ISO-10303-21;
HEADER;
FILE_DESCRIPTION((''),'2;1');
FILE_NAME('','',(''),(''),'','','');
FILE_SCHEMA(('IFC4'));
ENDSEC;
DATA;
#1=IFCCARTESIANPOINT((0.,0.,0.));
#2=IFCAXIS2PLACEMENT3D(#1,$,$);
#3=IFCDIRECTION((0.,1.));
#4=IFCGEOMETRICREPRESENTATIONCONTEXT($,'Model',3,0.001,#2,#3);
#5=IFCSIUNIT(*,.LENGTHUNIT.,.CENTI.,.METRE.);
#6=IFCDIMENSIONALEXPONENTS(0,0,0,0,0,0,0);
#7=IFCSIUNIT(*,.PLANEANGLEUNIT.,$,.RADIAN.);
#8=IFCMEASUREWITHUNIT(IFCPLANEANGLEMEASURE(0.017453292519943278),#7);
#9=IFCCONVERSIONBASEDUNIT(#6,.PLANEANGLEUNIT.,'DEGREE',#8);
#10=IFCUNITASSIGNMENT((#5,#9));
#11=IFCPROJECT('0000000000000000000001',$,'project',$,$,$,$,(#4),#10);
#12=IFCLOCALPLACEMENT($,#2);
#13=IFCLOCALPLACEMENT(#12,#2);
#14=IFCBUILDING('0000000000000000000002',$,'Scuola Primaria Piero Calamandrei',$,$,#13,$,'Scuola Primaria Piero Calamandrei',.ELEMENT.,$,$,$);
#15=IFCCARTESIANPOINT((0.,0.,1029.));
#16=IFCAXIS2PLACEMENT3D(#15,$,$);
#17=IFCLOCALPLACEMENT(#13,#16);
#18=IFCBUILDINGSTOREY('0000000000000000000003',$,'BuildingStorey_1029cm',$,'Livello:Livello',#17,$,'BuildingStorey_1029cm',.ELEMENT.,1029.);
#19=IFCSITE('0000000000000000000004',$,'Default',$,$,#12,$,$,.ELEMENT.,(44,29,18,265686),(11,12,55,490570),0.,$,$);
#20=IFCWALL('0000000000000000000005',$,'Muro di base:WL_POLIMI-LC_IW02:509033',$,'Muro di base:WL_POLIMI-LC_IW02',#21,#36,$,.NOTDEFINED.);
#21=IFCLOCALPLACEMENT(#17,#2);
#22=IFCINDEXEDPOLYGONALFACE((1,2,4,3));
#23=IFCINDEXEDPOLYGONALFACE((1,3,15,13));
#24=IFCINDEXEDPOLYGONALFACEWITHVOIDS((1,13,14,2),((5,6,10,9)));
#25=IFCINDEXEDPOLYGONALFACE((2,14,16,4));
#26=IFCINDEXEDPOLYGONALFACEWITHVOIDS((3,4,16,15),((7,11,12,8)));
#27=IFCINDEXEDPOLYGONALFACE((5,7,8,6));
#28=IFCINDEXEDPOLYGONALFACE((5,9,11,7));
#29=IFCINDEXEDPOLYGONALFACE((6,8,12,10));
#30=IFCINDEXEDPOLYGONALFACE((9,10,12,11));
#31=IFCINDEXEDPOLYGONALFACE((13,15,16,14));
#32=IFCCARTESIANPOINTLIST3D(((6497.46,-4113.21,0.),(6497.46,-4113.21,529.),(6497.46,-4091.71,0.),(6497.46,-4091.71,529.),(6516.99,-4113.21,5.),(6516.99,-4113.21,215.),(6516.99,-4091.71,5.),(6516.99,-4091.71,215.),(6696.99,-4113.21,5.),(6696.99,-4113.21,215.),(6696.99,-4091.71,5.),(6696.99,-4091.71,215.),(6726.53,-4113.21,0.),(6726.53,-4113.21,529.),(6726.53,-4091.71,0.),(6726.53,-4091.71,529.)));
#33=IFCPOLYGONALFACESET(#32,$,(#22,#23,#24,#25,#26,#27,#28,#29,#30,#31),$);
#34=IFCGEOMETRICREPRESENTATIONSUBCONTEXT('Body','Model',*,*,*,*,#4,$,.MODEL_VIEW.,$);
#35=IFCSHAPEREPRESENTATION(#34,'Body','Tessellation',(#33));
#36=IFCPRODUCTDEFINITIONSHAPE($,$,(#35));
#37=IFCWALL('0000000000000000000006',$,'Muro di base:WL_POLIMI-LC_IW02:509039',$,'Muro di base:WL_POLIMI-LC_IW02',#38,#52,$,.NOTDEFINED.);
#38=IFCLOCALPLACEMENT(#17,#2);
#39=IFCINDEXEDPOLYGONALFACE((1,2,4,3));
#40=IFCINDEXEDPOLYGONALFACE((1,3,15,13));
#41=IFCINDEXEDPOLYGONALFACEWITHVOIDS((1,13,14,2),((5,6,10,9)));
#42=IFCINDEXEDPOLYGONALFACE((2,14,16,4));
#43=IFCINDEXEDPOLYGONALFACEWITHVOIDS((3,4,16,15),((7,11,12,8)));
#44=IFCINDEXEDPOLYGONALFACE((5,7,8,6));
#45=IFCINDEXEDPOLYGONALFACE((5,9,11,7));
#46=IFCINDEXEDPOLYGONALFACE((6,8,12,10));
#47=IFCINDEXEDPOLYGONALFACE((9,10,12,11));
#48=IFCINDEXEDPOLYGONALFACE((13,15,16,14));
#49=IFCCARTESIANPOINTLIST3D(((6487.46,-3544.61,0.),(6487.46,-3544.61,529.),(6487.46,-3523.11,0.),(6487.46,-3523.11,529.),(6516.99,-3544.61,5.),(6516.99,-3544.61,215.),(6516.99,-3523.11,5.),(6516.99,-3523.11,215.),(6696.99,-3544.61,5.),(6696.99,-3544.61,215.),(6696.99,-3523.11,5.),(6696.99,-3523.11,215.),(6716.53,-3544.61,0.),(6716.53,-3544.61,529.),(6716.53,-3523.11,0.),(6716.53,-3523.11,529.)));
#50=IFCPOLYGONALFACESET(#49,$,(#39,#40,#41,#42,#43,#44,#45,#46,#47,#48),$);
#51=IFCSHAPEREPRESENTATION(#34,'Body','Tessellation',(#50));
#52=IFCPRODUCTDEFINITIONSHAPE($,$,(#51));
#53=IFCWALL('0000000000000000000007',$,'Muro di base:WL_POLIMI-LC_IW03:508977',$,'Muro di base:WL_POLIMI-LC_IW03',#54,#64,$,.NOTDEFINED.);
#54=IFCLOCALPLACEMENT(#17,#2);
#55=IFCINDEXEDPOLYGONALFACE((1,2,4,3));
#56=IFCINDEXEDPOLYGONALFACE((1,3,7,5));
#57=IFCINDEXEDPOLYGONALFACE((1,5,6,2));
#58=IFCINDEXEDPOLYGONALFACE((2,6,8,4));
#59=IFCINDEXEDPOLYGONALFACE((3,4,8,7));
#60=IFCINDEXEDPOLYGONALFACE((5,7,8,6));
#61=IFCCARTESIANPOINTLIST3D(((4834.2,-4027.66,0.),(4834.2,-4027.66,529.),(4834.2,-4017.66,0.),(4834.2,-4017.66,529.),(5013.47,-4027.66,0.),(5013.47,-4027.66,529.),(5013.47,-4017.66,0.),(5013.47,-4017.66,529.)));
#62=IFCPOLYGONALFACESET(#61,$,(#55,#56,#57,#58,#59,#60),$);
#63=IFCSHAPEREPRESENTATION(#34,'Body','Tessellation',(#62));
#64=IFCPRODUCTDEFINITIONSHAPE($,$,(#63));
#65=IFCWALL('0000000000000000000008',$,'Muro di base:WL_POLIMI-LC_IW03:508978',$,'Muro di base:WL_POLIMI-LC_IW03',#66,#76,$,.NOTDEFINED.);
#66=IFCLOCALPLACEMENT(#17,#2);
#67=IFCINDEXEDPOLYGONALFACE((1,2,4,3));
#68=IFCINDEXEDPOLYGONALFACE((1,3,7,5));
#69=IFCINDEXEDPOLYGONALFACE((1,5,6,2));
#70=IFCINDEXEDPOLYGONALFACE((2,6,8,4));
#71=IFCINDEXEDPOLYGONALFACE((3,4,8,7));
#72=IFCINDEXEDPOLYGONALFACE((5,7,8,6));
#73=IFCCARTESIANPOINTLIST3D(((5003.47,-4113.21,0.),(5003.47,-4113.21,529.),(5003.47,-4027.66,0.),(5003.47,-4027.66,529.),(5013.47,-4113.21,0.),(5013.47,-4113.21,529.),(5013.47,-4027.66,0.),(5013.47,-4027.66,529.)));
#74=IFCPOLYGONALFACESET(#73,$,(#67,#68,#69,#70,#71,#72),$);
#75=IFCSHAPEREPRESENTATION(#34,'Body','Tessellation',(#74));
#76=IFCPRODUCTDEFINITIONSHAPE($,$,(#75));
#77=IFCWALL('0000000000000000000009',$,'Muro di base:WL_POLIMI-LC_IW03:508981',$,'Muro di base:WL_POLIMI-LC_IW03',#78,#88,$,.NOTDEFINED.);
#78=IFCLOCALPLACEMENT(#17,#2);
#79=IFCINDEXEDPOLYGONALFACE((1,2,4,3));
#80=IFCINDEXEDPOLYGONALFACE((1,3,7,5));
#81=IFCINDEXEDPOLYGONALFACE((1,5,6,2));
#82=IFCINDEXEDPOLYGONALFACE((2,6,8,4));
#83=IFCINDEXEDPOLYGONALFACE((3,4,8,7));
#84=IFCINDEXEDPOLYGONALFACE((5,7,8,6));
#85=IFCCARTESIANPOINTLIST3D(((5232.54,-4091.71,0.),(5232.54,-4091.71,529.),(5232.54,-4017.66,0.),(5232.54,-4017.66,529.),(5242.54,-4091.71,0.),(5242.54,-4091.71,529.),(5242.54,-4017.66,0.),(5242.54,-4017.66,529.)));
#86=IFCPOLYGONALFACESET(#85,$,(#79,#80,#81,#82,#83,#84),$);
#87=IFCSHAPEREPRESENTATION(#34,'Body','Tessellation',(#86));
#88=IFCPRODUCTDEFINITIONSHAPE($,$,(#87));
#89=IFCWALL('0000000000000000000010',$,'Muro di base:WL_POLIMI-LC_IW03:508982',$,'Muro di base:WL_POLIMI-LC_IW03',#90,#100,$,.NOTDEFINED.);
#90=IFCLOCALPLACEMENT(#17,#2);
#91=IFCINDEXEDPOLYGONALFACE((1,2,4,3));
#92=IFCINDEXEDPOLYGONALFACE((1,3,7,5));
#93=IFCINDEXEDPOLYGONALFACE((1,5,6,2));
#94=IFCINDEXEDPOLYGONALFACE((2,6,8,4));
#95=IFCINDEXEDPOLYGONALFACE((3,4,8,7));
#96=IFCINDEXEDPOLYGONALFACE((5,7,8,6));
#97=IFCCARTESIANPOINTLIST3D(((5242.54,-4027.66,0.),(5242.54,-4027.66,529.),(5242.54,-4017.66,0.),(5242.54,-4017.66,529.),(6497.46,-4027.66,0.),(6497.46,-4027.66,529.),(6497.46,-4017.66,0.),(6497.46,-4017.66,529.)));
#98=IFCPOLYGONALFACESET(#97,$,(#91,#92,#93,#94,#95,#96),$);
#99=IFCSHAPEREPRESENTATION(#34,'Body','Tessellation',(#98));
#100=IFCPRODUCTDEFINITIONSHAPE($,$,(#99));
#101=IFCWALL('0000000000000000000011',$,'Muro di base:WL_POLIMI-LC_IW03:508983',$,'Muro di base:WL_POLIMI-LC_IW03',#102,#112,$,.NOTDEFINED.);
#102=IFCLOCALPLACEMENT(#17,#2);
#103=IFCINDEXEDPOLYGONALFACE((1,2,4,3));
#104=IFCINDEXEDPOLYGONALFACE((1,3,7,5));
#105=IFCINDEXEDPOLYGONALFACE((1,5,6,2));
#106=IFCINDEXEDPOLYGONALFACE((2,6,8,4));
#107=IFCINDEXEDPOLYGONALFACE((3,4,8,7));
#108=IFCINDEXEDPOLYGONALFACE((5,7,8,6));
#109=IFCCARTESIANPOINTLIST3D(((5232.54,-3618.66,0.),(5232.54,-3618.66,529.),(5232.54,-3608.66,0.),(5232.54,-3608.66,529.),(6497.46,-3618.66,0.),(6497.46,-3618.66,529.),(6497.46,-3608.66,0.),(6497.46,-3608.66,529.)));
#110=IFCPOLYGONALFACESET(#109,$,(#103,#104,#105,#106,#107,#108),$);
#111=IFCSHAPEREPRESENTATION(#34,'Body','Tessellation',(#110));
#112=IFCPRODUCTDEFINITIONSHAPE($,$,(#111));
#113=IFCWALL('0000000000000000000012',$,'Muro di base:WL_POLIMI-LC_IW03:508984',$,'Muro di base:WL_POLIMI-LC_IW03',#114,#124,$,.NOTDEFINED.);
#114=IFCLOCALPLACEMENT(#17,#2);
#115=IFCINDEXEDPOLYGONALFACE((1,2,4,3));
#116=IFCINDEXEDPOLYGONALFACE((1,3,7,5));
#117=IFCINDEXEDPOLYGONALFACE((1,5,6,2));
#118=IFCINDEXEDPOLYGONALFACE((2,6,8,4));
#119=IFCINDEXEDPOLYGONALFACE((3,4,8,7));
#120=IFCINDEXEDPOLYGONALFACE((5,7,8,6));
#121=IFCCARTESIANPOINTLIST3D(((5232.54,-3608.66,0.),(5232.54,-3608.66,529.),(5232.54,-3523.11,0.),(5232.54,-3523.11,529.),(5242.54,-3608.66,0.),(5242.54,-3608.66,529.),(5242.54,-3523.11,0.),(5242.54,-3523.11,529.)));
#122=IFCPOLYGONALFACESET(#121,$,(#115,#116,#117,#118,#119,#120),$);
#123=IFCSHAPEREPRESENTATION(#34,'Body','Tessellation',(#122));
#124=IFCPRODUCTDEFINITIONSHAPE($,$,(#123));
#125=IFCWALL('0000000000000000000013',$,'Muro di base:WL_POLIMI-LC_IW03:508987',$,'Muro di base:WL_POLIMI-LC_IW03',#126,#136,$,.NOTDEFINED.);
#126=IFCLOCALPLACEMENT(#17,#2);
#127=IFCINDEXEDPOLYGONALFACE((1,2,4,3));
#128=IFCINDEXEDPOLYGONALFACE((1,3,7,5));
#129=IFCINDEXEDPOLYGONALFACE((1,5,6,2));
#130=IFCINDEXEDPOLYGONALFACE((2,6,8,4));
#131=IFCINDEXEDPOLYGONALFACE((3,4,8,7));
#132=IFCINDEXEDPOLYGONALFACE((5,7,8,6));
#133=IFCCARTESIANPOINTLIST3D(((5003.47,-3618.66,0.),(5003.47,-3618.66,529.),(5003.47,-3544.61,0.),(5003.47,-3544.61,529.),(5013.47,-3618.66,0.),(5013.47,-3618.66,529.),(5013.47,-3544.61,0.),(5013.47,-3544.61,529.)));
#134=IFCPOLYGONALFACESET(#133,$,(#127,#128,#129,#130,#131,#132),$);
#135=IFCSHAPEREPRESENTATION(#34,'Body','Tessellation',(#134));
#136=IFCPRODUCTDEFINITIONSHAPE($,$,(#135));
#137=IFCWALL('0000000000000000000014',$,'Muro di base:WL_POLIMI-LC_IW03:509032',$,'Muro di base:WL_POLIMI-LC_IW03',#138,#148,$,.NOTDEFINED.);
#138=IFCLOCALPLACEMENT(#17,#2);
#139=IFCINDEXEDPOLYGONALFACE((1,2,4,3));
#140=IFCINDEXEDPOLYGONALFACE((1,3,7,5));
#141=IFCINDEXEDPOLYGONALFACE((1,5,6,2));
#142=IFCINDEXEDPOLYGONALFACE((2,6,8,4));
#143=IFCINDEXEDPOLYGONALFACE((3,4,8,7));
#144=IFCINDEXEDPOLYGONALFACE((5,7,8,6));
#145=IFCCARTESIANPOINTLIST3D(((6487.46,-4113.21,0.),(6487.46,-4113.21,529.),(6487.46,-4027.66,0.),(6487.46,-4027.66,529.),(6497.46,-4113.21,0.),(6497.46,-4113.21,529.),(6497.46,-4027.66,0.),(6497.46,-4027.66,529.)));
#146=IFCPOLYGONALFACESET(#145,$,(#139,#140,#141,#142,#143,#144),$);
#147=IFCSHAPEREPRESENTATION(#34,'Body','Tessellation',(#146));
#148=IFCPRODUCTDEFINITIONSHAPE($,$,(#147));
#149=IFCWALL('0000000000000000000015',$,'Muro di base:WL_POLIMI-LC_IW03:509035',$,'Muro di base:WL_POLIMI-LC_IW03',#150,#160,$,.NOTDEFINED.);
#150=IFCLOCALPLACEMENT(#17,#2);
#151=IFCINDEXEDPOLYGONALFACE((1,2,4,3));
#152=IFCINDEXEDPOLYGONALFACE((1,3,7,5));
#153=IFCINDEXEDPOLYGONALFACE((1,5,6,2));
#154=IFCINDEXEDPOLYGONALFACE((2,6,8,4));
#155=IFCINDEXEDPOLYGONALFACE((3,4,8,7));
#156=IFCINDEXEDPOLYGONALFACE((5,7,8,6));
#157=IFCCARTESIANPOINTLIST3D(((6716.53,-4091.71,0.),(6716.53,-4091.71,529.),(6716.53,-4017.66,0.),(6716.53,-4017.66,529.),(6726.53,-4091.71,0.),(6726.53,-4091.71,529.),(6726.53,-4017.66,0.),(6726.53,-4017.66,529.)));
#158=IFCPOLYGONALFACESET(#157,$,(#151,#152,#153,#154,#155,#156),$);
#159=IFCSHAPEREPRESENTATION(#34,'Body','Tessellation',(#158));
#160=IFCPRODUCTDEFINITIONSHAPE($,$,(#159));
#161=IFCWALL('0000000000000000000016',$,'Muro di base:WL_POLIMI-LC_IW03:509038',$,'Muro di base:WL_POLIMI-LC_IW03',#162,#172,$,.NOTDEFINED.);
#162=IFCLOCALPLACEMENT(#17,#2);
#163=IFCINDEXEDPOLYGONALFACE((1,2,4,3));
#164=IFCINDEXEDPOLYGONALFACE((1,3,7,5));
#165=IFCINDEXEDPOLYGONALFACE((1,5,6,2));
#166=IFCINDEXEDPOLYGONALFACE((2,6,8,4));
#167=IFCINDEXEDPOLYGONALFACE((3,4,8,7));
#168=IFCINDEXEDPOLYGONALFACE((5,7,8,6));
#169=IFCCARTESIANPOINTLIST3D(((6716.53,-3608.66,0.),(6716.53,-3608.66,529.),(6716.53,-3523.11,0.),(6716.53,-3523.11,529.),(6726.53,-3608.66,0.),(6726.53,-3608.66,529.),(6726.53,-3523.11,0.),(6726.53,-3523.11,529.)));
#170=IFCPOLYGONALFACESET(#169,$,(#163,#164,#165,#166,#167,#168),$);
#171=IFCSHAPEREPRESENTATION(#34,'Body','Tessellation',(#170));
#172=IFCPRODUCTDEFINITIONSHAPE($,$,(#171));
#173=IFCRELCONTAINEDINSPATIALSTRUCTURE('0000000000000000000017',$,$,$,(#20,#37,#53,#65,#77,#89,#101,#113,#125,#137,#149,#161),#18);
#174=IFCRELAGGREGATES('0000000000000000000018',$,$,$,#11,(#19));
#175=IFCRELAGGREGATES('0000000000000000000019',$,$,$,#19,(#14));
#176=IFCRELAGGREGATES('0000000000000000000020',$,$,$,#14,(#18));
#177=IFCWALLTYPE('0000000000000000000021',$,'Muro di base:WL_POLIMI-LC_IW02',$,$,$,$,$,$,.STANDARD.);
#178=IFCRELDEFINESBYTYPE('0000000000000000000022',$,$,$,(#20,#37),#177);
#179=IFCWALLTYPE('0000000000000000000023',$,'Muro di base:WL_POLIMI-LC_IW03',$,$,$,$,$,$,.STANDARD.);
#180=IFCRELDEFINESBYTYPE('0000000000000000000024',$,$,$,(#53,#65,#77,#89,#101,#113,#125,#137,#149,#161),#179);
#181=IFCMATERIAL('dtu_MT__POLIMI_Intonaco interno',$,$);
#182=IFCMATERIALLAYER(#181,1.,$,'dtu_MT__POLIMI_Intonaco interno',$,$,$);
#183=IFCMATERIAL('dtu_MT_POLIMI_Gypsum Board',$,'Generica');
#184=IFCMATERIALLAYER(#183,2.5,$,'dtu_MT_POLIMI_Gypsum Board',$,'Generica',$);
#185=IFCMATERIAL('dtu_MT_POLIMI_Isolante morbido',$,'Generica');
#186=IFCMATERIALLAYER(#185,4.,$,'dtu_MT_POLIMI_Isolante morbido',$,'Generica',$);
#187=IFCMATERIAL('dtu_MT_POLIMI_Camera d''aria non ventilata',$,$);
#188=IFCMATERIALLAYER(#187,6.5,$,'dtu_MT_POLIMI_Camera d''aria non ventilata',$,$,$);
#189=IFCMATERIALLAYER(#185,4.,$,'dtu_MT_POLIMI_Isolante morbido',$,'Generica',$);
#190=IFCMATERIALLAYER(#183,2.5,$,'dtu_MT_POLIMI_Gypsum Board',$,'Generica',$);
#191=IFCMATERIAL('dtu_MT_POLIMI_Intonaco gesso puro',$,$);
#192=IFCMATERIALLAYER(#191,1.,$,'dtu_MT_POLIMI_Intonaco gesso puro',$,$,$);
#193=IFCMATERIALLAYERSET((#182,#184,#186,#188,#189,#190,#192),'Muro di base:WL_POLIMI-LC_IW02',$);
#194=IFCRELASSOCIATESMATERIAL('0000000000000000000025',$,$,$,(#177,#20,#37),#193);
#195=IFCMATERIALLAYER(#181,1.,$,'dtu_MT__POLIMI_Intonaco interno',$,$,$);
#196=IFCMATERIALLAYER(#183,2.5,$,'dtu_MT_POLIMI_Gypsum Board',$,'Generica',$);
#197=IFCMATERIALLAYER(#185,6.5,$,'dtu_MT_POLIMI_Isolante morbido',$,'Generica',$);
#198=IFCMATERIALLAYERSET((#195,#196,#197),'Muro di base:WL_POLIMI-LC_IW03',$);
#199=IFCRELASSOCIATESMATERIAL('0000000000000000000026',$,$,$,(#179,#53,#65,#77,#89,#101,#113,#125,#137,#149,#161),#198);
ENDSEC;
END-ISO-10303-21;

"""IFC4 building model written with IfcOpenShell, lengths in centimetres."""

from ifc_helpers import new_model, entity, si_unit, converted_unit, direction, frame, frame_2d, origin, place, context, subcontext, project, spatial, rectangle, extrude, material, layer, layer_set, layer_usage, type_object, element, save


model = new_model("IFC4")

# Units and contexts
model_context = context("Model", 3, precision=0.001, world=origin(), true_north=direction((0.0, 1.0)))
body_context = subcontext(model_context, "Body", "Model", "MODEL_VIEW")
ifc_project = project(units=[si_unit("LENGTHUNIT", "METRE", prefix="CENTI"), converted_unit("PLANEANGLEUNIT", "DEGREE", entity("IfcPlaneAngleMeasure", 0.017453292519943278), si_unit("PLANEANGLEUNIT", "RADIAN"), dimensions=[0, 0, 0, 0, 0, 0, 0])], contexts=[model_context])

# Site, building, storey
site_placement = place(None, origin())
site = spatial("IfcSite", under=ifc_project, at=site_placement, Name="Default", CompositionType="ELEMENT", RefLatitude=(44, 29, 18, 265686), RefLongitude=(11, 12, 55, 490570), RefElevation=0.0)
building_placement = place(site_placement, origin())
building = spatial("IfcBuilding", under=site, at=building_placement, Name="Scuola Primaria Piero Calamandrei", LongName="Scuola Primaria Piero Calamandrei", CompositionType="ELEMENT")
storey_placement = place(building_placement, frame((0.0, 0.0, 1029.0)))
storey = spatial("IfcBuildingStorey", under=building, at=storey_placement, Name="BuildingStorey_1029cm", ObjectType="Livello:Livello", LongName="BuildingStorey_1029cm", CompositionType="ELEMENT", Elevation=1029.0)

# Shared definitions
ifc_material_1 = material(Name="dtu_MT_POLIMI_Isolante morbido", Category="Generica")
ifc_material_2 = material(Name="dtu_MT_POLIMI_Gypsum Board", Category="Generica")
ifc_material_3 = material(Name="dtu_MT__POLIMI_Intonaco interno")

# Walls, openings
ifc_layer_1 = layer(ifc_material_3, 1.0, Name="dtu_MT__POLIMI_Intonaco interno")
ifc_layer_2 = layer(ifc_material_2, 2.5, Name="dtu_MT_POLIMI_Gypsum Board", Category="Generica")
ifc_layer_3 = layer(ifc_material_1, 4.0, Name="dtu_MT_POLIMI_Isolante morbido", Category="Generica")
ifc_material_4 = material(Name="dtu_MT_POLIMI_Camera d'aria non ventilata")
ifc_layer_4 = layer(ifc_material_4, 6.5, Name="dtu_MT_POLIMI_Camera d'aria non ventilata")
ifc_layer_5 = layer(ifc_material_1, 4.0, Name="dtu_MT_POLIMI_Isolante morbido", Category="Generica")
ifc_layer_6 = layer(ifc_material_2, 2.5, Name="dtu_MT_POLIMI_Gypsum Board", Category="Generica")
ifc_material_5 = material(Name="dtu_MT_POLIMI_Intonaco gesso puro")
ifc_layer_7 = layer(ifc_material_5, 1.0, Name="dtu_MT_POLIMI_Intonaco gesso puro")
ifc_layer_set_1 = layer_set([ifc_layer_1, ifc_layer_2, ifc_layer_3, ifc_layer_4, ifc_layer_5, ifc_layer_6, ifc_layer_7], Name="Muro di base:WL_POLIMI-LC_IW02")
wall_type_1 = type_object("IfcWallType", Name="Muro di base:WL_POLIMI-LC_IW02", PredefinedType="STANDARD", material=ifc_layer_set_1)
ifc_layer_usage_1 = layer_usage(ifc_layer_set_1, "AXIS2", "NEGATIVE", 10.75)
wall_1_placement = place(storey_placement, frame((6726.53, -4102.46, 0.0), z_axis=(0.0, 0.0, 1.0), x_axis=(-1.0, 0.0, 0.0)))
wall_1 = element("IfcWall", 1, at=wall_1_placement, inside=storey, type_object=wall_type_1, material=ifc_layer_usage_1, Name="Muro di base:WL_POLIMI-LC_IW02:509033", ObjectType="Muro di base:WL_POLIMI-LC_IW02", PredefinedType="NOTDEFINED", context=body_context, shape_type="SweptSolid", body=[
    extrude(rectangle(XDim=229.07, YDim=21.5, at=frame_2d((114.54, 0.0), x_axis=(-1.0, 0.0))), origin(), (0.0, 0.0, 1.0), 529.0),
])
opening_1_placement = place(wall_1_placement, frame((209.54, 10.75, 5.0)))
element("IfcOpeningElement", 2, at=opening_1_placement, cuts=wall_1, PredefinedType="OPENING", context=body_context, shape_type="SweptSolid", body=[
    extrude(rectangle(XDim=210.0, YDim=180.0, at=frame_2d((105.0, 90.0), x_axis=(-1.0, 0.0))), frame((0.0, 0.0, 0.0), z_axis=(0.0, -1.0, 0.0), x_axis=(0.0, 0.0, 1.0)), (0.0, 0.0, 1.0), 21.5),
])
ifc_layer_usage_2 = layer_usage(ifc_layer_set_1, "AXIS2", "NEGATIVE", 10.75)
wall_2_placement = place(storey_placement, frame((6487.46, -3533.86, 0.0)))
wall_2 = element("IfcWall", 3, at=wall_2_placement, inside=storey, type_object=wall_type_1, material=ifc_layer_usage_2, Name="Muro di base:WL_POLIMI-LC_IW02:509039", ObjectType="Muro di base:WL_POLIMI-LC_IW02", PredefinedType="NOTDEFINED", context=body_context, shape_type="SweptSolid", body=[
    extrude(rectangle(XDim=229.07, YDim=21.5, at=frame_2d((114.54, 0.0), x_axis=(-1.0, 0.0))), origin(), (0.0, 0.0, 1.0), 529.0),
])
opening_2_placement = place(wall_2_placement, frame((209.54, 10.75, 5.0)))
element("IfcOpeningElement", 4, at=opening_2_placement, cuts=wall_2, PredefinedType="OPENING", context=body_context, shape_type="SweptSolid", body=[
    extrude(rectangle(XDim=210.0, YDim=180.0, at=frame_2d((105.0, 90.0), x_axis=(-1.0, 0.0))), frame((0.0, 0.0, 0.0), z_axis=(0.0, -1.0, 0.0), x_axis=(0.0, 0.0, 1.0)), (0.0, 0.0, 1.0), 21.5),
])

# Walls
ifc_layer_8 = layer(ifc_material_3, 1.0, Name="dtu_MT__POLIMI_Intonaco interno")
ifc_layer_9 = layer(ifc_material_2, 2.5, Name="dtu_MT_POLIMI_Gypsum Board", Category="Generica")
ifc_layer_10 = layer(ifc_material_1, 6.5, Name="dtu_MT_POLIMI_Isolante morbido", Category="Generica")
ifc_layer_set_2 = layer_set([ifc_layer_8, ifc_layer_9, ifc_layer_10], Name="Muro di base:WL_POLIMI-LC_IW03")
ifc_layer_usage_3 = layer_usage(ifc_layer_set_2, "AXIS2", "NEGATIVE", 5.0)
wall_type_2 = type_object("IfcWallType", Name="Muro di base:WL_POLIMI-LC_IW03", PredefinedType="STANDARD", material=ifc_layer_set_2)
wall_3_placement = place(storey_placement, frame((5013.47, -4022.66, 0.0), z_axis=(0.0, 0.0, 1.0), x_axis=(-1.0, 0.0, 0.0)))
element("IfcWall", 5, at=wall_3_placement, inside=storey, type_object=wall_type_2, material=ifc_layer_usage_3, Name="Muro di base:WL_POLIMI-LC_IW03:508977", ObjectType="Muro di base:WL_POLIMI-LC_IW03", PredefinedType="NOTDEFINED", context=body_context, shape_type="SweptSolid", body=[
    extrude(rectangle(XDim=179.27, YDim=10.0, at=frame_2d((89.64, 0.0), x_axis=(-1.0, 0.0))), origin(), (0.0, 0.0, 1.0), 529.0),
])
ifc_layer_usage_4 = layer_usage(ifc_layer_set_2, "AXIS2", "NEGATIVE", 5.0)
wall_4_placement = place(storey_placement, frame((5008.47, -4113.21, 0.0), z_axis=(0.0, 0.0, 1.0), x_axis=(0.0, 1.0, 0.0)))
element("IfcWall", 6, at=wall_4_placement, inside=storey, type_object=wall_type_2, material=ifc_layer_usage_4, Name="Muro di base:WL_POLIMI-LC_IW03:508978", ObjectType="Muro di base:WL_POLIMI-LC_IW03", PredefinedType="NOTDEFINED", context=body_context, shape_type="SweptSolid", body=[
    extrude(rectangle(XDim=85.55, YDim=10.0, at=frame_2d((42.78, 0.0), x_axis=(-1.0, 0.0))), origin(), (0.0, 0.0, 1.0), 529.0),
])
ifc_layer_usage_5 = layer_usage(ifc_layer_set_2, "AXIS2", "NEGATIVE", 5.0)
wall_5_placement = place(storey_placement, frame((5237.54, -4017.66, 0.0), z_axis=(0.0, 0.0, 1.0), x_axis=(0.0, -1.0, 0.0)))
element("IfcWall", 7, at=wall_5_placement, inside=storey, type_object=wall_type_2, material=ifc_layer_usage_5, Name="Muro di base:WL_POLIMI-LC_IW03:508981", ObjectType="Muro di base:WL_POLIMI-LC_IW03", PredefinedType="NOTDEFINED", context=body_context, shape_type="SweptSolid", body=[
    extrude(rectangle(XDim=74.05, YDim=10.0, at=frame_2d((37.03, 0.0), x_axis=(-1.0, 0.0))), origin(), (0.0, 0.0, 1.0), 529.0),
])
ifc_layer_usage_6 = layer_usage(ifc_layer_set_2, "AXIS2", "NEGATIVE", 5.0)
wall_6_placement = place(storey_placement, frame((6497.46, -4022.66, 0.0), z_axis=(0.0, 0.0, 1.0), x_axis=(-1.0, 0.0, 0.0)))
element("IfcWall", 8, at=wall_6_placement, inside=storey, type_object=wall_type_2, material=ifc_layer_usage_6, Name="Muro di base:WL_POLIMI-LC_IW03:508982", ObjectType="Muro di base:WL_POLIMI-LC_IW03", PredefinedType="NOTDEFINED", context=body_context, shape_type="SweptSolid", body=[
    extrude(rectangle(XDim=1254.91, YDim=10.0, at=frame_2d((627.46, 0.0), x_axis=(-1.0, 0.0))), origin(), (0.0, 0.0, 1.0), 529.0),
])
ifc_layer_usage_7 = layer_usage(ifc_layer_set_2, "AXIS2", "NEGATIVE", 5.0)
wall_7_placement = place(storey_placement, frame((5232.54, -3613.66, 0.0)))
element("IfcWall", 9, at=wall_7_placement, inside=storey, type_object=wall_type_2, material=ifc_layer_usage_7, Name="Muro di base:WL_POLIMI-LC_IW03:508983", ObjectType="Muro di base:WL_POLIMI-LC_IW03", PredefinedType="NOTDEFINED", context=body_context, shape_type="SweptSolid", body=[
    extrude(rectangle(XDim=1264.91, YDim=10.0, at=frame_2d((632.46, 0.0), x_axis=(-1.0, 0.0))), origin(), (0.0, 0.0, 1.0), 529.0),
])
ifc_layer_usage_8 = layer_usage(ifc_layer_set_2, "AXIS2", "NEGATIVE", 5.0)
wall_8_placement = place(storey_placement, frame((5237.54, -3523.11, 0.0), z_axis=(0.0, 0.0, 1.0), x_axis=(0.0, -1.0, 0.0)))
element("IfcWall", 10, at=wall_8_placement, inside=storey, type_object=wall_type_2, material=ifc_layer_usage_8, Name="Muro di base:WL_POLIMI-LC_IW03:508984", ObjectType="Muro di base:WL_POLIMI-LC_IW03", PredefinedType="NOTDEFINED", context=body_context, shape_type="SweptSolid", body=[
    extrude(rectangle(XDim=85.55, YDim=10.0, at=frame_2d((42.78, 0.0), x_axis=(-1.0, 0.0))), origin(), (0.0, 0.0, 1.0), 529.0),
])
ifc_layer_usage_9 = layer_usage(ifc_layer_set_2, "AXIS2", "NEGATIVE", 5.0)
wall_9_placement = place(storey_placement, frame((5008.47, -3618.66, 0.0), z_axis=(0.0, 0.0, 1.0), x_axis=(0.0, 1.0, 0.0)))
element("IfcWall", 11, at=wall_9_placement, inside=storey, type_object=wall_type_2, material=ifc_layer_usage_9, Name="Muro di base:WL_POLIMI-LC_IW03:508987", ObjectType="Muro di base:WL_POLIMI-LC_IW03", PredefinedType="NOTDEFINED", context=body_context, shape_type="SweptSolid", body=[
    extrude(rectangle(XDim=74.05, YDim=10.0, at=frame_2d((37.03, 0.0), x_axis=(-1.0, 0.0))), origin(), (0.0, 0.0, 1.0), 529.0),
])
ifc_layer_usage_10 = layer_usage(ifc_layer_set_2, "AXIS2", "NEGATIVE", 5.0)
wall_10_placement = place(storey_placement, frame((6492.46, -4113.21, 0.0), z_axis=(0.0, 0.0, 1.0), x_axis=(0.0, 1.0, 0.0)))
element("IfcWall", 12, at=wall_10_placement, inside=storey, type_object=wall_type_2, material=ifc_layer_usage_10, Name="Muro di base:WL_POLIMI-LC_IW03:509032", ObjectType="Muro di base:WL_POLIMI-LC_IW03", PredefinedType="NOTDEFINED", context=body_context, shape_type="SweptSolid", body=[
    extrude(rectangle(XDim=85.55, YDim=10.0, at=frame_2d((42.78, 0.0), x_axis=(-1.0, 0.0))), origin(), (0.0, 0.0, 1.0), 529.0),
])
ifc_layer_usage_11 = layer_usage(ifc_layer_set_2, "AXIS2", "NEGATIVE", 5.0)
wall_11_placement = place(storey_placement, frame((6721.53, -4017.66, 0.0), z_axis=(0.0, 0.0, 1.0), x_axis=(0.0, -1.0, 0.0)))
element("IfcWall", 13, at=wall_11_placement, inside=storey, type_object=wall_type_2, material=ifc_layer_usage_11, Name="Muro di base:WL_POLIMI-LC_IW03:509035", ObjectType="Muro di base:WL_POLIMI-LC_IW03", PredefinedType="NOTDEFINED", context=body_context, shape_type="SweptSolid", body=[
    extrude(rectangle(XDim=74.05, YDim=10.0, at=frame_2d((37.03, 0.0), x_axis=(-1.0, 0.0))), origin(), (0.0, 0.0, 1.0), 529.0),
])
ifc_layer_usage_12 = layer_usage(ifc_layer_set_2, "AXIS2", "NEGATIVE", 5.0)
wall_12_placement = place(storey_placement, frame((6721.53, -3523.11, 0.0), z_axis=(0.0, 0.0, 1.0), x_axis=(0.0, -1.0, 0.0)))
element("IfcWall", 14, at=wall_12_placement, inside=storey, type_object=wall_type_2, material=ifc_layer_usage_12, Name="Muro di base:WL_POLIMI-LC_IW03:509038", ObjectType="Muro di base:WL_POLIMI-LC_IW03", PredefinedType="NOTDEFINED", context=body_context, shape_type="SweptSolid", body=[
    extrude(rectangle(XDim=85.55, YDim=10.0, at=frame_2d((42.78, 0.0), x_axis=(-1.0, 0.0))), origin(), (0.0, 0.0, 1.0), 529.0),
])

save(model, "model.ifc")
